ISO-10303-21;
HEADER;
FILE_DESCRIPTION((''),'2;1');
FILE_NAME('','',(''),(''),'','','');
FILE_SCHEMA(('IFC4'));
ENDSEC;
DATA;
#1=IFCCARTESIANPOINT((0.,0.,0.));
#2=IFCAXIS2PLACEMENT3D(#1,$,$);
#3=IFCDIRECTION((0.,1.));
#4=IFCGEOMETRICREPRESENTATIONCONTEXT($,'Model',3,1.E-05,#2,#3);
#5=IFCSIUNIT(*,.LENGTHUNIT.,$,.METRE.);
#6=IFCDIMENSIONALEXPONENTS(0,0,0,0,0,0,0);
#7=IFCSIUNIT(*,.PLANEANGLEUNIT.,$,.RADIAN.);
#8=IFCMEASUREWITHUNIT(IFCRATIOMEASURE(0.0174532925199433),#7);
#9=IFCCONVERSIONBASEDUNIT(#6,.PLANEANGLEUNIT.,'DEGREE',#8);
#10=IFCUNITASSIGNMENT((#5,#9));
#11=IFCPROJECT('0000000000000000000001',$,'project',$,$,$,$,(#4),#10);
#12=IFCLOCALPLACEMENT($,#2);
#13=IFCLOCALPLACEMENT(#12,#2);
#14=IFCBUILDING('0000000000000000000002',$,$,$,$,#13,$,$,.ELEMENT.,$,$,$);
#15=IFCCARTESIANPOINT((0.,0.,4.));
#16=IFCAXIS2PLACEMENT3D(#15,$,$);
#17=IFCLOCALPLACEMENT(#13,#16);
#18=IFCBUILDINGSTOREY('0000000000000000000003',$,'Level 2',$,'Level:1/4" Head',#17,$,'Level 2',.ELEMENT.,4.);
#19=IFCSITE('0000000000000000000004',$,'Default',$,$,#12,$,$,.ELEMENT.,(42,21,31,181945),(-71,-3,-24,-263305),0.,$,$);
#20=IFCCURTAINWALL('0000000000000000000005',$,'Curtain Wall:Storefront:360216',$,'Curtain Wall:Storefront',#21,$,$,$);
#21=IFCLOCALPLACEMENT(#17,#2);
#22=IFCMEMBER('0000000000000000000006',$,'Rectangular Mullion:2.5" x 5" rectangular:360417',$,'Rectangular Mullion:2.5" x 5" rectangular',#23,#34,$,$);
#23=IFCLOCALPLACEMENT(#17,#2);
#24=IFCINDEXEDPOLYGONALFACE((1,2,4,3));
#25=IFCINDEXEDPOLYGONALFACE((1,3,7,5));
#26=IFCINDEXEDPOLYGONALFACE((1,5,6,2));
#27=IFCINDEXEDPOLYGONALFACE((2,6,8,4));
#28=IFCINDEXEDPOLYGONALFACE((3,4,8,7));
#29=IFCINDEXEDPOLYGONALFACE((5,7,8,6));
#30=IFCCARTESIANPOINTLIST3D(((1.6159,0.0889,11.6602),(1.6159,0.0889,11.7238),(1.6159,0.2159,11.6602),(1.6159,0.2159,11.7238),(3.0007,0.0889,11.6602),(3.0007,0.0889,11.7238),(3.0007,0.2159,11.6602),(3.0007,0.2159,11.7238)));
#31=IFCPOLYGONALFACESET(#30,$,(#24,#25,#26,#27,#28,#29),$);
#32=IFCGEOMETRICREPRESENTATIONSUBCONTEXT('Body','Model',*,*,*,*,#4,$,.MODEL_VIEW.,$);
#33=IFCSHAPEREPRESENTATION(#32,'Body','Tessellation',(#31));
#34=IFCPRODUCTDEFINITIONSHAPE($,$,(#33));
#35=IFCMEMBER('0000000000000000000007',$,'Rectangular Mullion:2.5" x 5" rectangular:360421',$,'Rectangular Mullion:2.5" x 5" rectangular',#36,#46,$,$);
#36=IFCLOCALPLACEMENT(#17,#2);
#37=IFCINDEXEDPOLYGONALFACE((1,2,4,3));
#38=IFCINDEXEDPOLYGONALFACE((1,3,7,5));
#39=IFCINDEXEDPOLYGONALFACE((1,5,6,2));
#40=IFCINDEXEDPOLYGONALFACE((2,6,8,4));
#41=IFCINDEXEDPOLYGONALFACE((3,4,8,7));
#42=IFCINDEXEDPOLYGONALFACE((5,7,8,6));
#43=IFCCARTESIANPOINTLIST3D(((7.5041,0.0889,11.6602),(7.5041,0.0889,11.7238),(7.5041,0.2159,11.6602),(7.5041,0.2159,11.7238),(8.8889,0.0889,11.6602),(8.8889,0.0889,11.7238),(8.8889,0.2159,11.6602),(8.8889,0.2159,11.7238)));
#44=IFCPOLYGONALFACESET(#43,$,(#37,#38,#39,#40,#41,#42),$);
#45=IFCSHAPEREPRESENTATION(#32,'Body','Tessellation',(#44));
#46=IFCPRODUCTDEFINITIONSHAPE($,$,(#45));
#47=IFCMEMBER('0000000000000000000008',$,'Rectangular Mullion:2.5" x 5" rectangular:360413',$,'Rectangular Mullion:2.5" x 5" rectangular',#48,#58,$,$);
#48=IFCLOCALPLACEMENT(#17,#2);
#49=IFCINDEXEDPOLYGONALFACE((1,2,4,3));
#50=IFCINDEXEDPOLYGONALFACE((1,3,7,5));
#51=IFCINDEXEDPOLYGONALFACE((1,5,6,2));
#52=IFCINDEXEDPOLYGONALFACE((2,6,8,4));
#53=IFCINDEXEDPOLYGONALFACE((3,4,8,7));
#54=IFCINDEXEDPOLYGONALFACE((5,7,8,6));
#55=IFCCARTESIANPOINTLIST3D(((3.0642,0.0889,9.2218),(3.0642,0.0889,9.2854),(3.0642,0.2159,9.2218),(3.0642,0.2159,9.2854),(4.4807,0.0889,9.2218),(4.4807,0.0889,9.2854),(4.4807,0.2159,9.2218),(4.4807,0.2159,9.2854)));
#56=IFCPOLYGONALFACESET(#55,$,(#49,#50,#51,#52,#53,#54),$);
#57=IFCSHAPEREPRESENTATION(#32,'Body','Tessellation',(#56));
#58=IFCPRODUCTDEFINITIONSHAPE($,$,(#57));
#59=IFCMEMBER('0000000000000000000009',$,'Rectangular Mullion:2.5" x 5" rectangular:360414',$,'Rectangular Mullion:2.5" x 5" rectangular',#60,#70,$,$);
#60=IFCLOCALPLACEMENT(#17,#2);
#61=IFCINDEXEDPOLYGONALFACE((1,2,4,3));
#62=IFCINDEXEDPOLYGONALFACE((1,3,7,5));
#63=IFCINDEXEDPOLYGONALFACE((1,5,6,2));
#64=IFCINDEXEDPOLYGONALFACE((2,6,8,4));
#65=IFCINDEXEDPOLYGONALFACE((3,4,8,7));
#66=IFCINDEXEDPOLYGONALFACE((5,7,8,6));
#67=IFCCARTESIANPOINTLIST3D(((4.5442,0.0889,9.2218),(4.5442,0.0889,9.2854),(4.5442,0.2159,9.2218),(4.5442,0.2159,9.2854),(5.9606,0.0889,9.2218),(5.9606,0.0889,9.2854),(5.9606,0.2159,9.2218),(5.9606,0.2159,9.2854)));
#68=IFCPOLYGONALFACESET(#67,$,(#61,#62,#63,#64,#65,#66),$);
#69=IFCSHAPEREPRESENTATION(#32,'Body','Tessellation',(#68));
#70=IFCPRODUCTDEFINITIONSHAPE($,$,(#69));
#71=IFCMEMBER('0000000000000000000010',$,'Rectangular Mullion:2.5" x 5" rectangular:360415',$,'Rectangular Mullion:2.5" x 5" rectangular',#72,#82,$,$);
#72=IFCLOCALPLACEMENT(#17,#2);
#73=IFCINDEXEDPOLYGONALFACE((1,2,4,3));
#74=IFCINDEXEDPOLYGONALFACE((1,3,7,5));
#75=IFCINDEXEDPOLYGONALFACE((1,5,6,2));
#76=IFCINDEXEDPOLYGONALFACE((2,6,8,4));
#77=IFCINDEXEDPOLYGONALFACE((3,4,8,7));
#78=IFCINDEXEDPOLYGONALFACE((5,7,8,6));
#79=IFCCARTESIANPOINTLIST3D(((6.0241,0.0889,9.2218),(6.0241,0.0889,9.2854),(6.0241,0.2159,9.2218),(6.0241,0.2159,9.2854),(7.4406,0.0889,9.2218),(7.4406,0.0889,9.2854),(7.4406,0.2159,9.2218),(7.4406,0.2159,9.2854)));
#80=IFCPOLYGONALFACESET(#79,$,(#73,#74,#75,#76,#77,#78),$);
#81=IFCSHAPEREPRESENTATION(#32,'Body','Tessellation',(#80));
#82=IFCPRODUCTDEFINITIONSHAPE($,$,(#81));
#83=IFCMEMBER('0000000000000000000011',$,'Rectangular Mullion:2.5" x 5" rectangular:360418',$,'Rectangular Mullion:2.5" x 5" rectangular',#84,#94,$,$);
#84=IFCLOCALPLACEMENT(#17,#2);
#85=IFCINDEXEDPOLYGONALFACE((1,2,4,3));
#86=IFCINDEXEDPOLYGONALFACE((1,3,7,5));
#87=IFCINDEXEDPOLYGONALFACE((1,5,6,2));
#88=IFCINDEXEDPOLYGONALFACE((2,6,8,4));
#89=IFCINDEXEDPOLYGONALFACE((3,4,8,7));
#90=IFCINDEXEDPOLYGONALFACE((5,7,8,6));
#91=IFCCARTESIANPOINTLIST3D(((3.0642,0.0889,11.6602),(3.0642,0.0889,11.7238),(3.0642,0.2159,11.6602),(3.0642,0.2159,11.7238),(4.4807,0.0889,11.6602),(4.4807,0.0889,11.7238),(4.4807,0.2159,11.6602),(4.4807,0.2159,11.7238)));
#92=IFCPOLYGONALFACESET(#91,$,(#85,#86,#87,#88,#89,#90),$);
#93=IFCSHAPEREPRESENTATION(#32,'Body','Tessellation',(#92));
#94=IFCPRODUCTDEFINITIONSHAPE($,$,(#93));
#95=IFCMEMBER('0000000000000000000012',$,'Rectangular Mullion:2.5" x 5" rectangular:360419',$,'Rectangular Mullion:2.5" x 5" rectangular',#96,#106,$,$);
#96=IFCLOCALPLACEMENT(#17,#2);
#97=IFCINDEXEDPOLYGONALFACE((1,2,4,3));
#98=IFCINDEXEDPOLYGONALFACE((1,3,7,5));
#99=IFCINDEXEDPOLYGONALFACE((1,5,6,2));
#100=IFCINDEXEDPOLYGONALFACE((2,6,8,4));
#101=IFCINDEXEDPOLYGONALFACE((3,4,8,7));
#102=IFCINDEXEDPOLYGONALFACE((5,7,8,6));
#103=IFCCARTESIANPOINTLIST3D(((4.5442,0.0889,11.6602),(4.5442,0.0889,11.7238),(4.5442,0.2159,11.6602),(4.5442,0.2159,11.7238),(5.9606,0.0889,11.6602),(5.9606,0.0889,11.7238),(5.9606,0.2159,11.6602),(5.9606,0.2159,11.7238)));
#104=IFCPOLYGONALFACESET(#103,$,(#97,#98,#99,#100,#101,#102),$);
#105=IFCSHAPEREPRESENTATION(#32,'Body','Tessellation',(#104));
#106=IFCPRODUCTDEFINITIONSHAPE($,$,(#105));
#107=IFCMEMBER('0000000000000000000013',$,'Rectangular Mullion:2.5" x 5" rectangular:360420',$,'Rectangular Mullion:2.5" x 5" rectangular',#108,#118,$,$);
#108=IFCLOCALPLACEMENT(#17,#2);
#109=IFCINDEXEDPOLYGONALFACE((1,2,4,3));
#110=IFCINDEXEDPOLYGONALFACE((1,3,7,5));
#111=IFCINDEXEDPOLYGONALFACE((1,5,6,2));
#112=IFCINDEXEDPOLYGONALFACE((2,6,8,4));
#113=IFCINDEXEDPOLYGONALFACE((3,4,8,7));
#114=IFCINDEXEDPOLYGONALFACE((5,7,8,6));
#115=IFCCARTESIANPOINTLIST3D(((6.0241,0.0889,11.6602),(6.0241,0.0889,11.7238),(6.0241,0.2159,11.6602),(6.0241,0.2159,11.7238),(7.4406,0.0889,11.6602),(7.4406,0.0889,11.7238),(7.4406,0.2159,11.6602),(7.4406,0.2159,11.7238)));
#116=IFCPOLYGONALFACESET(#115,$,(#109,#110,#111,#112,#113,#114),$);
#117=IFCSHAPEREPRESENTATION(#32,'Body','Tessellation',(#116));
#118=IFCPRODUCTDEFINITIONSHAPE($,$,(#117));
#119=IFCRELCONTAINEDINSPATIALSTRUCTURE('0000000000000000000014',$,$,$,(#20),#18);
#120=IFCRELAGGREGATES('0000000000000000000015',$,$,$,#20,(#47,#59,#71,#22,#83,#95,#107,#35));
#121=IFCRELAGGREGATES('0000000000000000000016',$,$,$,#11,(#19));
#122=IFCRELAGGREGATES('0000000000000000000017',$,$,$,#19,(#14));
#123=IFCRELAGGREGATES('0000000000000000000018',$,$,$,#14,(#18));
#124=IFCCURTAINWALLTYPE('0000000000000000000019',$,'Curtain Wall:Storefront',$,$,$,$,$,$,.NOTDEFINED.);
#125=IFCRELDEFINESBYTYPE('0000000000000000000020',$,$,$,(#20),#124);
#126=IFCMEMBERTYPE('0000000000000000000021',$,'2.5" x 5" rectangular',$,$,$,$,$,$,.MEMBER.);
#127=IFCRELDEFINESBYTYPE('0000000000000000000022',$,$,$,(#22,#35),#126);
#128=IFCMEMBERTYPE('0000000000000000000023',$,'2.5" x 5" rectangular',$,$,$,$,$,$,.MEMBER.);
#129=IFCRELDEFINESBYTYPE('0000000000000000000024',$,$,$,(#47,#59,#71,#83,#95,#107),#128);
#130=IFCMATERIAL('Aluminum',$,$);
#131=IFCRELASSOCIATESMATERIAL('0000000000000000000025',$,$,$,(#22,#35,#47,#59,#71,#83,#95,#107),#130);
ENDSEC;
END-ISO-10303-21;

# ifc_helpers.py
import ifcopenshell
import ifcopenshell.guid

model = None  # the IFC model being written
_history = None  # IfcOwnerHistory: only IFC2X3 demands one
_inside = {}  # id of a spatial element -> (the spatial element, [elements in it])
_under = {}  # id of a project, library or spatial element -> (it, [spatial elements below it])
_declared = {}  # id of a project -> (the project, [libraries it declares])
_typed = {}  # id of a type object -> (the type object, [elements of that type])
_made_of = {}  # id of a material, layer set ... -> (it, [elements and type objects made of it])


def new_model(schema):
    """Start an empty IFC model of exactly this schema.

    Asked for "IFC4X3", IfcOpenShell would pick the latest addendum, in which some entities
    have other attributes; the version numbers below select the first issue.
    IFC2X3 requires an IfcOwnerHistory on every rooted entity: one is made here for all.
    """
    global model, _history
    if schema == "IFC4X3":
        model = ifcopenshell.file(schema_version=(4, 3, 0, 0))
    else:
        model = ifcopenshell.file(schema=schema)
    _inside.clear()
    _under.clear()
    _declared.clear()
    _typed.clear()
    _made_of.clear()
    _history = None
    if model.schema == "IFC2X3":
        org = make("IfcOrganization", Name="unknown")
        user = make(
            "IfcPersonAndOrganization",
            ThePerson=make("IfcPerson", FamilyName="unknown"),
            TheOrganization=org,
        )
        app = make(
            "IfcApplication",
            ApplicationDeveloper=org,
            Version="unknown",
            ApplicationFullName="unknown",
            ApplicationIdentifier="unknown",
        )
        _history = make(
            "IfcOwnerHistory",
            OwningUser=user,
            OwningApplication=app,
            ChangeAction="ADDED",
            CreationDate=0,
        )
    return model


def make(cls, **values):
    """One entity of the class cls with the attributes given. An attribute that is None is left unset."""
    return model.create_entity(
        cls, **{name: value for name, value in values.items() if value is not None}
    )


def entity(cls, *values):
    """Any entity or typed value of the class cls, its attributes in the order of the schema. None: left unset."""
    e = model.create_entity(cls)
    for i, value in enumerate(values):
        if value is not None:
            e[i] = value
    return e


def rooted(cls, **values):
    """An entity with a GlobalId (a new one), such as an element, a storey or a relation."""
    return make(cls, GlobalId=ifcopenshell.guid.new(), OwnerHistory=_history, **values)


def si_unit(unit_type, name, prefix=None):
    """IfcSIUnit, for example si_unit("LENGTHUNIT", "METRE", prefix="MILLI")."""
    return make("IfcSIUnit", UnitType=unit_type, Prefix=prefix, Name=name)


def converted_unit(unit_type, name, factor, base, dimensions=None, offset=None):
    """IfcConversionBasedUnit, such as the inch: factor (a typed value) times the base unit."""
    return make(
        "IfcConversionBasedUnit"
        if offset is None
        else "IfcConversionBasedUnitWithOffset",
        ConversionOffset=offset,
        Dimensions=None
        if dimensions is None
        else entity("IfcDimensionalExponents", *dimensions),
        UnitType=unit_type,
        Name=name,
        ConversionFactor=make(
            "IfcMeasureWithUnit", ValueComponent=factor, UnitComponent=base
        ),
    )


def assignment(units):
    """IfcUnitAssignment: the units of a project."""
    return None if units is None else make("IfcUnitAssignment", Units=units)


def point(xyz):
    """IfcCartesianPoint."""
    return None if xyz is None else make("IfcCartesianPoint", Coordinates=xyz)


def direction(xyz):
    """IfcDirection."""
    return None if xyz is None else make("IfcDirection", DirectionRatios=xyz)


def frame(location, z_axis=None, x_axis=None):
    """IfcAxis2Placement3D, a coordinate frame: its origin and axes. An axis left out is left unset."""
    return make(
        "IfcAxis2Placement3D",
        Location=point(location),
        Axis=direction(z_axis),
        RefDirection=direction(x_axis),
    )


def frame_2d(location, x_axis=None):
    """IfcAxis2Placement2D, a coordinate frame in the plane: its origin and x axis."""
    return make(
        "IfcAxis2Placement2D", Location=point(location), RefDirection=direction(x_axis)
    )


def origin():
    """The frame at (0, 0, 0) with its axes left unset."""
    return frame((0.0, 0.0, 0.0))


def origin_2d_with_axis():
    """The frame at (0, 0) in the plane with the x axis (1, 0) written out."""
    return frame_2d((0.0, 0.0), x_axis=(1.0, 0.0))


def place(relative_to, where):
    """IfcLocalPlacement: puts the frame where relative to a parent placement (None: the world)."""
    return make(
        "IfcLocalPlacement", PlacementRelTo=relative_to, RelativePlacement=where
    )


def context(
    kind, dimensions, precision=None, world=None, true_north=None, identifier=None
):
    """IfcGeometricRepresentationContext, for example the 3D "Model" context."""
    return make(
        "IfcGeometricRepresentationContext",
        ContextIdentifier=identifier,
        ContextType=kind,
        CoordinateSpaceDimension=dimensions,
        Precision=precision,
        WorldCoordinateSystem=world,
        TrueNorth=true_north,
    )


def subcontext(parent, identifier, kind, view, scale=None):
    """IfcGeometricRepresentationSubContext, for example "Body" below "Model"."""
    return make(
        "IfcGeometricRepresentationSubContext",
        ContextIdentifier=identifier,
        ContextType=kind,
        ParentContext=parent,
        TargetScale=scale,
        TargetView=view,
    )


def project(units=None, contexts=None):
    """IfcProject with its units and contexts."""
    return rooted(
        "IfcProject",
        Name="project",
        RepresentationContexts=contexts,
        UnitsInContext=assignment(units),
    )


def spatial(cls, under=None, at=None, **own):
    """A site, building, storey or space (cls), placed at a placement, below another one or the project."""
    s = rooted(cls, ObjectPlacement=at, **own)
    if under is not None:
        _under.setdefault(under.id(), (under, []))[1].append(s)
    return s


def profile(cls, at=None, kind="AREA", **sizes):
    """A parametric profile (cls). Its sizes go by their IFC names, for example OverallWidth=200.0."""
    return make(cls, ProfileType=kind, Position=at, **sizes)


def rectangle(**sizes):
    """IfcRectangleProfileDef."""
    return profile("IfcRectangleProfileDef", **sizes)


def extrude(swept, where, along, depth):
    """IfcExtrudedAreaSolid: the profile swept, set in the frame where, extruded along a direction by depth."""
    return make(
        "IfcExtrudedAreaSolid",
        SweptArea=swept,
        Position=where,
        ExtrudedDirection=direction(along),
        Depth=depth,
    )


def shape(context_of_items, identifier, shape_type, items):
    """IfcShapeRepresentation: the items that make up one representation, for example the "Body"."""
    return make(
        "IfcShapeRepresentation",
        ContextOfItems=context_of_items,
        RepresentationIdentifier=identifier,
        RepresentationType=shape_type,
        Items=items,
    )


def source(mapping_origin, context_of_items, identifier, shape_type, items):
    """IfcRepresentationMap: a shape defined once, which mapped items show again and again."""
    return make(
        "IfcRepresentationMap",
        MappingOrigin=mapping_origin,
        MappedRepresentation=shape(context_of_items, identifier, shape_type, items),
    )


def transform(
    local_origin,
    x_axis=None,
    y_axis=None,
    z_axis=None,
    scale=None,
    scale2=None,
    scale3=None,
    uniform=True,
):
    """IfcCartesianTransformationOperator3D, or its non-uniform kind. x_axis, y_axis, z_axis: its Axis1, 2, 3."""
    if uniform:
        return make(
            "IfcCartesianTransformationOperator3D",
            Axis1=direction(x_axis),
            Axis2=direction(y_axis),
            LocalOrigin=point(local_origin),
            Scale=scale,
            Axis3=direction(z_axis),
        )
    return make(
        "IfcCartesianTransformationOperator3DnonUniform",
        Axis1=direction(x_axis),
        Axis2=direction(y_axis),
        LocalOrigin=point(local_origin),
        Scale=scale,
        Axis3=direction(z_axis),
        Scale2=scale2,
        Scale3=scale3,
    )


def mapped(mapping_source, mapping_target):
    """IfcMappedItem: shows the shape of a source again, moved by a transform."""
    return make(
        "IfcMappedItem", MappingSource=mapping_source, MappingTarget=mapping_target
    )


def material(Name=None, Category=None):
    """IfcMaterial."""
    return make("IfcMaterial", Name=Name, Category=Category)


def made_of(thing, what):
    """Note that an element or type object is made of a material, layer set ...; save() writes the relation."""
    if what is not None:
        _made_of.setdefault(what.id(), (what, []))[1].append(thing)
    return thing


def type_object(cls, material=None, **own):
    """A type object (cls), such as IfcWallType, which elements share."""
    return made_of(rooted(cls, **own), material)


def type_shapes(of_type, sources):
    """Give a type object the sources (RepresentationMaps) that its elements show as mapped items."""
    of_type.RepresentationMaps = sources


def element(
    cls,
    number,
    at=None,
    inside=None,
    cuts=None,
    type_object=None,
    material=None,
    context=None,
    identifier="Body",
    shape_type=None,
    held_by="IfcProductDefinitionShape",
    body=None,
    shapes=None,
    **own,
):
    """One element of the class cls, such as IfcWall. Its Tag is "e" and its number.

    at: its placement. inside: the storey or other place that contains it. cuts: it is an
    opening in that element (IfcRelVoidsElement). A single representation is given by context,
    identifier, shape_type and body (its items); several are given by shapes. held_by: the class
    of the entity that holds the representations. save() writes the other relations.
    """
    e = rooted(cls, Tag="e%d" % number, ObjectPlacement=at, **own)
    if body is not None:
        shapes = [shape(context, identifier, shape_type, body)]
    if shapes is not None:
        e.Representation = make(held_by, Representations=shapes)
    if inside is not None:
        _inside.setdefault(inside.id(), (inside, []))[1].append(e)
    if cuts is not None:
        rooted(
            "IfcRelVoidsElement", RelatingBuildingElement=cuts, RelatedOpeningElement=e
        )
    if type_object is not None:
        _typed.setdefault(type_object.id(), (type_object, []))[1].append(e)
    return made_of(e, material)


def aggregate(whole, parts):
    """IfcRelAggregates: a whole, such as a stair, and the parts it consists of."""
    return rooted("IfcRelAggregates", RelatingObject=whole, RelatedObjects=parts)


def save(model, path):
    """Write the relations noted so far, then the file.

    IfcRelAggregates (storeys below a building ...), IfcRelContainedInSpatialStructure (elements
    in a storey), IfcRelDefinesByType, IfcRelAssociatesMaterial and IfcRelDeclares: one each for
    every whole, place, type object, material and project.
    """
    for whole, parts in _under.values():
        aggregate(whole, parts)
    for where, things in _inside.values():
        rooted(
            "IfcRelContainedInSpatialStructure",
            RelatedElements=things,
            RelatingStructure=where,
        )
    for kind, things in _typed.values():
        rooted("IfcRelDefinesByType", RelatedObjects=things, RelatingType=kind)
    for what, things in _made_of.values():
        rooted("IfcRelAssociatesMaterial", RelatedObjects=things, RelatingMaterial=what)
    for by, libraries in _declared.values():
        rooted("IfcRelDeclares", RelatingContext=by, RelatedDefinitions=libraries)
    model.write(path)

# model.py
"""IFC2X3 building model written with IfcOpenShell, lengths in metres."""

from ifc_helpers import new_model, entity, si_unit, converted_unit, direction, frame, origin, origin_2d_with_axis, place, context, subcontext, project, spatial, rectangle, extrude, source, transform, mapped, material, type_object, type_shapes, element, aggregate, save


model = new_model("IFC2X3")

# Units and contexts
model_context = context("Model", 3, precision=1e-05, world=origin(), true_north=direction((0.0, 1.0)))
body_context = subcontext(model_context, "Body", "Model", "MODEL_VIEW")
ifc_project = project(units=[si_unit("LENGTHUNIT", "METRE"), converted_unit("PLANEANGLEUNIT", "DEGREE", entity("IfcRatioMeasure", 0.0174532925199433), si_unit("PLANEANGLEUNIT", "RADIAN"), dimensions=[0, 0, 0, 0, 0, 0, 0])], contexts=[model_context])

# Site, building, storey
site_placement = place(None, origin())
site = spatial("IfcSite", under=ifc_project, at=site_placement, Name="Default", CompositionType="ELEMENT", RefLatitude=(42, 21, 31, 181945), RefLongitude=(-71, -3, -24, -263305), RefElevation=0.0)
building_placement = place(site_placement, origin())
building = spatial("IfcBuilding", under=site, at=building_placement, CompositionType="ELEMENT")
storey_placement = place(building_placement, frame((0.0, 0.0, 4.0)))
storey = spatial("IfcBuildingStorey", under=building, at=storey_placement, Name="Level 2", ObjectType="Level:1/4\" Head", LongName="Level 2", CompositionType="ELEMENT", Elevation=4.0)

# Curtain wall, members
curtain_wall_type = type_object("IfcCurtainWallType", Name="Curtain Wall:Storefront", PredefinedType="NOTDEFINED")
curtain_wall_placement = place(storey_placement, frame((0.0, 0.0, -4.0)))
curtain_wall = element("IfcCurtainWall", 1, at=curtain_wall_placement, inside=storey, type_object=curtain_wall_type, Name="Curtain Wall:Storefront:360216", ObjectType="Curtain Wall:Storefront")
ifc_material_1 = material(Name="Aluminum")
member_type_1 = type_object("IfcMemberType", Name="2.5\" x 5\" rectangular", PredefinedType="MEMBER")
shared_shape_1 = source(origin(), body_context, "Body", "SweptSolid", [
    extrude(rectangle(XDim=0.127, YDim=0.0635, at=origin_2d_with_axis()), frame((0.0, 0.0, -1.3848), z_axis=(0.0, 0.0, 1.0), x_axis=(0.0, -1.0, 0.0)), (0.0, 0.0, 1.0), 1.3848),
])
type_shapes(member_type_1, [shared_shape_1])
member_1_placement = place(storey_placement, frame((3.0007, 0.1524, 11.692), z_axis=(1.0, 0.0, 0.0), x_axis=(0.0, 0.0, 1.0)))
member_1 = element("IfcMember", 2, at=member_1_placement, type_object=member_type_1, material=ifc_material_1, Name="Rectangular Mullion:2.5\" x 5\" rectangular:360417", ObjectType="Rectangular Mullion:2.5\" x 5\" rectangular", context=body_context, shape_type="MappedRepresentation", body=[
    mapped(shared_shape_1, transform((0.0, 0.0, 0.0), scale=1.0)),
])
member_2_placement = place(storey_placement, frame((8.8889, 0.1524, 11.692), z_axis=(1.0, 0.0, 0.0), x_axis=(0.0, 0.0, 1.0)))
member_2 = element("IfcMember", 3, at=member_2_placement, type_object=member_type_1, material=ifc_material_1, Name="Rectangular Mullion:2.5\" x 5\" rectangular:360421", ObjectType="Rectangular Mullion:2.5\" x 5\" rectangular", context=body_context, shape_type="MappedRepresentation", body=[
    mapped(shared_shape_1, transform((0.0, 0.0, 0.0), scale=1.0)),
])
member_type_2 = type_object("IfcMemberType", Name="2.5\" x 5\" rectangular", PredefinedType="MEMBER")
shared_shape_2 = source(origin(), body_context, "Body", "SweptSolid", [
    extrude(rectangle(XDim=0.127, YDim=0.0635, at=origin_2d_with_axis()), frame((0.0, 0.0, -1.4165), z_axis=(0.0, 0.0, 1.0), x_axis=(0.0, -1.0, 0.0)), (0.0, 0.0, 1.0), 1.4165),
])
type_shapes(member_type_2, [shared_shape_2])
member_3_placement = place(storey_placement, frame((4.4807, 0.1524, 9.2536), z_axis=(1.0, 0.0, 0.0), x_axis=(0.0, 0.0, 1.0)))
member_3 = element("IfcMember", 4, at=member_3_placement, type_object=member_type_2, material=ifc_material_1, Name="Rectangular Mullion:2.5\" x 5\" rectangular:360413", ObjectType="Rectangular Mullion:2.5\" x 5\" rectangular", context=body_context, shape_type="MappedRepresentation", body=[
    mapped(shared_shape_2, transform((0.0, 0.0, 0.0), scale=1.0)),
])
member_4_placement = place(storey_placement, frame((5.9606, 0.1524, 9.2536), z_axis=(1.0, 0.0, 0.0), x_axis=(0.0, 0.0, 1.0)))
member_4 = element("IfcMember", 5, at=member_4_placement, type_object=member_type_2, material=ifc_material_1, Name="Rectangular Mullion:2.5\" x 5\" rectangular:360414", ObjectType="Rectangular Mullion:2.5\" x 5\" rectangular", context=body_context, shape_type="MappedRepresentation", body=[
    mapped(shared_shape_2, transform((0.0, 0.0, 0.0), scale=1.0)),
])
member_5_placement = place(storey_placement, frame((7.4406, 0.1524, 9.2536), z_axis=(1.0, 0.0, 0.0), x_axis=(0.0, 0.0, 1.0)))
member_5 = element("IfcMember", 6, at=member_5_placement, type_object=member_type_2, material=ifc_material_1, Name="Rectangular Mullion:2.5\" x 5\" rectangular:360415", ObjectType="Rectangular Mullion:2.5\" x 5\" rectangular", context=body_context, shape_type="MappedRepresentation", body=[
    mapped(shared_shape_2, transform((0.0, 0.0, 0.0), scale=1.0)),
])
member_6_placement = place(storey_placement, frame((4.4807, 0.1524, 11.692), z_axis=(1.0, 0.0, 0.0), x_axis=(0.0, 0.0, 1.0)))
member_6 = element("IfcMember", 7, at=member_6_placement, type_object=member_type_2, material=ifc_material_1, Name="Rectangular Mullion:2.5\" x 5\" rectangular:360418", ObjectType="Rectangular Mullion:2.5\" x 5\" rectangular", context=body_context, shape_type="MappedRepresentation", body=[
    mapped(shared_shape_2, transform((0.0, 0.0, 0.0), scale=1.0)),
])
member_7_placement = place(storey_placement, frame((5.9606, 0.1524, 11.692), z_axis=(1.0, 0.0, 0.0), x_axis=(0.0, 0.0, 1.0)))
member_7 = element("IfcMember", 8, at=member_7_placement, type_object=member_type_2, material=ifc_material_1, Name="Rectangular Mullion:2.5\" x 5\" rectangular:360419", ObjectType="Rectangular Mullion:2.5\" x 5\" rectangular", context=body_context, shape_type="MappedRepresentation", body=[
    mapped(shared_shape_2, transform((0.0, 0.0, 0.0), scale=1.0)),
])
member_8_placement = place(storey_placement, frame((7.4406, 0.1524, 11.692), z_axis=(1.0, 0.0, 0.0), x_axis=(0.0, 0.0, 1.0)))
member_8 = element("IfcMember", 9, at=member_8_placement, type_object=member_type_2, material=ifc_material_1, Name="Rectangular Mullion:2.5\" x 5\" rectangular:360420", ObjectType="Rectangular Mullion:2.5\" x 5\" rectangular", context=body_context, shape_type="MappedRepresentation", body=[
    mapped(shared_shape_2, transform((0.0, 0.0, 0.0), scale=1.0)),
])
aggregate(curtain_wall, [member_3, member_4, member_5, member_1, member_6, member_7, member_8, member_2])

save(model, "model.ifc")
